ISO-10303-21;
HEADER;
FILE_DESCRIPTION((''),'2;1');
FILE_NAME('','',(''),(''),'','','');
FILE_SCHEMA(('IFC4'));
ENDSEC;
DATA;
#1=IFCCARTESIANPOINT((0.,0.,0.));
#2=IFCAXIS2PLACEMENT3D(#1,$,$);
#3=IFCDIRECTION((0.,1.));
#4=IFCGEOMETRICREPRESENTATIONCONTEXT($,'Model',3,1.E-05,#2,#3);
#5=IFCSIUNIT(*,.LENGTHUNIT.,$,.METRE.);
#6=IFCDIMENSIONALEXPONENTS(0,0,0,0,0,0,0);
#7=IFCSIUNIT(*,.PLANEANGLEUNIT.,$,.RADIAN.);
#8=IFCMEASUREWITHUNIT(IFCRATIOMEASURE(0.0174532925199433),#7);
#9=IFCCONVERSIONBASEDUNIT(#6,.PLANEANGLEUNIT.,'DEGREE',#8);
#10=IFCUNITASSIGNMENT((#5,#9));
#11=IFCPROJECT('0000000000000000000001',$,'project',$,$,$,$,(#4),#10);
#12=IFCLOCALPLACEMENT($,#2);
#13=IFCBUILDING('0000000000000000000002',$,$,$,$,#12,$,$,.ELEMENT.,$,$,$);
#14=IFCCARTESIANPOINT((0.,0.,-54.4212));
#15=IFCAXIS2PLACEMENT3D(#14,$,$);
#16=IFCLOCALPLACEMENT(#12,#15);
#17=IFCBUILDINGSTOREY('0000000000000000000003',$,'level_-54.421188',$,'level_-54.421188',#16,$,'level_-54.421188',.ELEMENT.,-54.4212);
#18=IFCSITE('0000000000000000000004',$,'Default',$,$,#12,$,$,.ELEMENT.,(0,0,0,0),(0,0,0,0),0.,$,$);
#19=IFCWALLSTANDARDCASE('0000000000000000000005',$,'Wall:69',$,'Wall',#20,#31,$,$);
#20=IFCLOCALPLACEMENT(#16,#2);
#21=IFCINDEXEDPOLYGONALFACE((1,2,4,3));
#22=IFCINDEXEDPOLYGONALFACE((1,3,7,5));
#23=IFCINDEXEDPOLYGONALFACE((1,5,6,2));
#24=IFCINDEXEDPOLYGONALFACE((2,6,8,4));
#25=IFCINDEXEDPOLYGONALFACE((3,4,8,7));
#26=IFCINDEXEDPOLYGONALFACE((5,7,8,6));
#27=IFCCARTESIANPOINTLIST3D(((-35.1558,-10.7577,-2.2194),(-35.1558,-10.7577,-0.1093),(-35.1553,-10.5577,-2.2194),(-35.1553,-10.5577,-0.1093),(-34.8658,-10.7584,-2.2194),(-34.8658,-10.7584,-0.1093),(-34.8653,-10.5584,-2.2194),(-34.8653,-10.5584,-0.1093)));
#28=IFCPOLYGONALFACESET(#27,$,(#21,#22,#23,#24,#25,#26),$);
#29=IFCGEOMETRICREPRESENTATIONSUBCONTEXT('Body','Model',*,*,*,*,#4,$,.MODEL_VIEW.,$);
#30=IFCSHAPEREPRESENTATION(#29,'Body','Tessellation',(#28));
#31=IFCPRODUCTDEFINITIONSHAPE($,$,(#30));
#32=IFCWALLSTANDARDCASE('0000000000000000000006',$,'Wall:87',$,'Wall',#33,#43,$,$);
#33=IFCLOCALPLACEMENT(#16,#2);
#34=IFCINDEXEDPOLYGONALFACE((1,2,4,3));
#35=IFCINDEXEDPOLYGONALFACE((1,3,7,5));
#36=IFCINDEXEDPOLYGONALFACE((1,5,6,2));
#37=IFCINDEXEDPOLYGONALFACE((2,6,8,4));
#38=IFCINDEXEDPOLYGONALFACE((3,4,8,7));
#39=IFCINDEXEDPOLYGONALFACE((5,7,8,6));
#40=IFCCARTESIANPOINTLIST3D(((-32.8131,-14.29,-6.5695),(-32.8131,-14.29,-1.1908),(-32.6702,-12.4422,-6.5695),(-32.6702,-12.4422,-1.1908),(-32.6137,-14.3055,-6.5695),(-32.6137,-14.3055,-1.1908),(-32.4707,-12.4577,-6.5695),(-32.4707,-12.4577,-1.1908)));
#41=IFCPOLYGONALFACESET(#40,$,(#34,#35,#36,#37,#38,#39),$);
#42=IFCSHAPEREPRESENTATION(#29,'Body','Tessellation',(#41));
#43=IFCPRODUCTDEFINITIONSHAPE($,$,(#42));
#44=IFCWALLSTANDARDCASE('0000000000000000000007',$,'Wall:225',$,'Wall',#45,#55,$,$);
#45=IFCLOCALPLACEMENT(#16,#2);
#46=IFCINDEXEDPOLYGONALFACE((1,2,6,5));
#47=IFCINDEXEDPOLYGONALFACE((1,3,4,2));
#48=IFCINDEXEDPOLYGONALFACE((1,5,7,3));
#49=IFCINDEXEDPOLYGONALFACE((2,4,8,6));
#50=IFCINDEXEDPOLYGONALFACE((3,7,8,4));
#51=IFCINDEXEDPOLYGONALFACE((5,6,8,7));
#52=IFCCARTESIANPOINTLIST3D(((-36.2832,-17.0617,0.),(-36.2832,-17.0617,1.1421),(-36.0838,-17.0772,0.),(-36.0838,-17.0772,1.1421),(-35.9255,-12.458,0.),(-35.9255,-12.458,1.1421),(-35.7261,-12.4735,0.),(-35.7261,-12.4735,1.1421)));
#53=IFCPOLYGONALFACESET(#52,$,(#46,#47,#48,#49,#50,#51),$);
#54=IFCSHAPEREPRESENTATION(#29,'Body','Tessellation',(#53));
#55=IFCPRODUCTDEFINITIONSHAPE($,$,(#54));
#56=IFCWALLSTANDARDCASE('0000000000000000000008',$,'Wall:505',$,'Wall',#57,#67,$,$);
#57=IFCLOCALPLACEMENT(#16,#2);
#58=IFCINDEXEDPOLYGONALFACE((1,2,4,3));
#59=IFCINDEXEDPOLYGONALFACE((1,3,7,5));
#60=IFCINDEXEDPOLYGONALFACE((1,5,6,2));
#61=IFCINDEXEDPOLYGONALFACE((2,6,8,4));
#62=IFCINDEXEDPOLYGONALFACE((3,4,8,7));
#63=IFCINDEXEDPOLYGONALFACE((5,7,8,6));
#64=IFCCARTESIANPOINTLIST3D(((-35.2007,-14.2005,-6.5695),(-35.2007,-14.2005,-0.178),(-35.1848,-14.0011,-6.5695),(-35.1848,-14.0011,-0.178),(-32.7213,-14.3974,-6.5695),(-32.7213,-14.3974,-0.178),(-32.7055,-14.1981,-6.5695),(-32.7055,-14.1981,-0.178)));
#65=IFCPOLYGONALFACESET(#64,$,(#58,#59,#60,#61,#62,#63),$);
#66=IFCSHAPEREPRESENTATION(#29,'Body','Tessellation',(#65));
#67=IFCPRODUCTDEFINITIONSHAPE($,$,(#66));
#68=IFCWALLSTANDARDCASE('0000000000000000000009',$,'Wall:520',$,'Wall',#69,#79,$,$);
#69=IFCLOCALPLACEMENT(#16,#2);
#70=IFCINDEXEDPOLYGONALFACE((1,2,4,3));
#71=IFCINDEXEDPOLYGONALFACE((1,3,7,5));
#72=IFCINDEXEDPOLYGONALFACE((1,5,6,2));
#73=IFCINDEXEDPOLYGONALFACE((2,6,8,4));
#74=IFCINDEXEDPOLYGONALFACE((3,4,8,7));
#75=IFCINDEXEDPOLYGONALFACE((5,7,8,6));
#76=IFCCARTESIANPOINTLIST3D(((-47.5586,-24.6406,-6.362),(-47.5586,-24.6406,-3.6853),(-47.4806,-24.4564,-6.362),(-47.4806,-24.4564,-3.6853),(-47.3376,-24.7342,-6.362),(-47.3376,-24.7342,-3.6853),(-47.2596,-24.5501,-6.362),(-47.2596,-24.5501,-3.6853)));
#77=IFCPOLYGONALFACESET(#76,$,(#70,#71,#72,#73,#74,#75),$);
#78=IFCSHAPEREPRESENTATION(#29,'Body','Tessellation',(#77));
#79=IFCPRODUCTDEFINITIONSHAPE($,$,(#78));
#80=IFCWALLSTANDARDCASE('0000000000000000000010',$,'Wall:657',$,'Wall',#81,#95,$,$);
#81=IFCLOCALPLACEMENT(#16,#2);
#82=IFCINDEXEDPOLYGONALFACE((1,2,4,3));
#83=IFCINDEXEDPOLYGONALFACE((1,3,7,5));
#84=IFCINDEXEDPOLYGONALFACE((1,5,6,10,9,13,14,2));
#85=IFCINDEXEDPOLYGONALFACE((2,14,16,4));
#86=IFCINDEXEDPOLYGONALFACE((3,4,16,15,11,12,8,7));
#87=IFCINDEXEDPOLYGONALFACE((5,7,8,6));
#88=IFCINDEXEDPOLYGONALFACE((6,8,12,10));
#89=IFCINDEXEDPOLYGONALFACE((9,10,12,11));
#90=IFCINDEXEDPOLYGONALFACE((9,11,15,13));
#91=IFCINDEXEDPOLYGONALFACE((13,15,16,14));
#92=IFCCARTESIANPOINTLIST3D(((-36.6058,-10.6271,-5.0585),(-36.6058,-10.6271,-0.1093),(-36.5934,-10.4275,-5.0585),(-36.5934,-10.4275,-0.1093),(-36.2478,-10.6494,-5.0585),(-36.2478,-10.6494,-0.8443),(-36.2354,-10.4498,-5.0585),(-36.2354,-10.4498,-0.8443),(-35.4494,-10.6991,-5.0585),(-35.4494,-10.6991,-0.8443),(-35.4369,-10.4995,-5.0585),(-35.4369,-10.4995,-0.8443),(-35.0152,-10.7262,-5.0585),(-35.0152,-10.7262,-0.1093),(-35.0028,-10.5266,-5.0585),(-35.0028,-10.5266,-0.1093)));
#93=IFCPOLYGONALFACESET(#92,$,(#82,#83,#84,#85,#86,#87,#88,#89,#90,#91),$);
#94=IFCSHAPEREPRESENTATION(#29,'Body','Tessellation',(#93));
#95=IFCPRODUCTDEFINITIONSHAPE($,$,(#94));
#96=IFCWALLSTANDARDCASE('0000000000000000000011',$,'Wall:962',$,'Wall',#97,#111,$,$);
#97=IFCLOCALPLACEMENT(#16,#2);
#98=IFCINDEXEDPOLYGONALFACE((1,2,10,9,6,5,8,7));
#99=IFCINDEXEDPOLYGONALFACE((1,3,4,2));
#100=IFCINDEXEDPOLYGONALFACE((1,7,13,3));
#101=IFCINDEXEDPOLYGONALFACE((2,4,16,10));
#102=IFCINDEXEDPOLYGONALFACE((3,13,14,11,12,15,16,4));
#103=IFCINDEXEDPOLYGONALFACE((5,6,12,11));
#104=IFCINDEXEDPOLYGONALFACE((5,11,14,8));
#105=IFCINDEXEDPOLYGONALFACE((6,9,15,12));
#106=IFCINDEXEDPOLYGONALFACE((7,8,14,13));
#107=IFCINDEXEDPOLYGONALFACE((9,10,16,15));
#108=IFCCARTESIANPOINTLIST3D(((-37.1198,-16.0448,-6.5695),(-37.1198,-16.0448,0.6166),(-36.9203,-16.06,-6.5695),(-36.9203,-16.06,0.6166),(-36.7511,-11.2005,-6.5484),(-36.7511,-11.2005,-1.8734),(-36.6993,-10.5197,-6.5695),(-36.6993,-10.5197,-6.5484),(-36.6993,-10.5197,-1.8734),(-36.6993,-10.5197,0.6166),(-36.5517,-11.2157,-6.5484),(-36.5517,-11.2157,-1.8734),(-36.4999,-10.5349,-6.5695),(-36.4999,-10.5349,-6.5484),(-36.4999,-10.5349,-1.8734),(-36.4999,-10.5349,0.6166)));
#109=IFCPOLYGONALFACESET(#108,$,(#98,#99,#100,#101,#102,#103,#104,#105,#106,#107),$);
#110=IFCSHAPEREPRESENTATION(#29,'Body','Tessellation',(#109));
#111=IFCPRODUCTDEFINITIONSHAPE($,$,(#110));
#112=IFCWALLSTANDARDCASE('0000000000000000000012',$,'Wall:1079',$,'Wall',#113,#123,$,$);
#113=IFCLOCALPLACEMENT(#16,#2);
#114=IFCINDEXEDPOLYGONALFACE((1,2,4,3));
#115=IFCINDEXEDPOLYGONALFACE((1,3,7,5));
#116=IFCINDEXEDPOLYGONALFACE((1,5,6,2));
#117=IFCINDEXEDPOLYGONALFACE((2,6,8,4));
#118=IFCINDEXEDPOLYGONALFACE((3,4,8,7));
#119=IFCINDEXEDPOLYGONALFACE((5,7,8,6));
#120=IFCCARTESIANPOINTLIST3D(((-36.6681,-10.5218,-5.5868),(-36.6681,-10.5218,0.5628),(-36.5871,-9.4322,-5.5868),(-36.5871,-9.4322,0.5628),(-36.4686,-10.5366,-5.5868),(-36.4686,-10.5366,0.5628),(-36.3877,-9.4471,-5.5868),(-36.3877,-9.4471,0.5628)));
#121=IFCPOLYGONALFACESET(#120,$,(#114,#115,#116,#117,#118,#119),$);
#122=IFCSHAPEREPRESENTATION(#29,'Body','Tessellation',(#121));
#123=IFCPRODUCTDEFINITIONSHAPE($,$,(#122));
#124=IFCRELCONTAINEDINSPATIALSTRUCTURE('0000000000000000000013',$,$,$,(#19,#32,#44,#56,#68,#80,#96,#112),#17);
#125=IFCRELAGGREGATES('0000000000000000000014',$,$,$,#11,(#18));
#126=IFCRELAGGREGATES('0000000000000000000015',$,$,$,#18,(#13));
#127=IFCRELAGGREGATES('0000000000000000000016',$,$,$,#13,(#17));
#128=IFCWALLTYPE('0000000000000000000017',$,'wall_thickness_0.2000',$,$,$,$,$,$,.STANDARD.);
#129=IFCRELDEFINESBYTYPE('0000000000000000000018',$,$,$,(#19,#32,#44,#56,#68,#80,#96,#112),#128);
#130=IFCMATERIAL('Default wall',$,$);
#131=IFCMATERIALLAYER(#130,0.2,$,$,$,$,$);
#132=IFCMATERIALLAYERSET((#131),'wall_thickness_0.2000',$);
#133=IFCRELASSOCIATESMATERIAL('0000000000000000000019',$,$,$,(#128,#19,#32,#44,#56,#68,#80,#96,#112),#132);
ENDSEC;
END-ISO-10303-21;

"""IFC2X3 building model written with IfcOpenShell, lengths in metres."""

from ifc_helpers import new_model, entity, si_unit, converted_unit, direction, frame, frame_2d, origin, place, context, subcontext, project, spatial, polyline, rectangle, outline, extrude, material, layer, layer_set, layer_usage, type_object, element, save


model = new_model("IFC2X3")

# Units and contexts
model_context = context("Model", 3, precision=1e-05, world=origin(), true_north=direction((0.0, 1.0)))
body_context = subcontext(model_context, "Body", "Model", "MODEL_VIEW")
ifc_project = project(units=[si_unit("LENGTHUNIT", "METRE"), converted_unit("PLANEANGLEUNIT", "DEGREE", entity("IfcRatioMeasure", 0.0174532925199433), si_unit("PLANEANGLEUNIT", "RADIAN"), dimensions=[0, 0, 0, 0, 0, 0, 0])], contexts=[model_context])

# Site, building, storey
placement_1 = place(None, origin())
site = spatial("IfcSite", under=ifc_project, at=placement_1, Name="Default", CompositionType="ELEMENT", RefLatitude=(0, 0, 0, 0), RefLongitude=(0, 0, 0, 0), RefElevation=0.0)
building = spatial("IfcBuilding", under=site, at=placement_1, CompositionType="ELEMENT")
storey_placement = place(placement_1, frame((0.0, 0.0, -54.4212)))
storey = spatial("IfcBuildingStorey", under=building, at=storey_placement, Name="level_-54.421188", ObjectType="level_-54.421188", LongName="level_-54.421188", CompositionType="ELEMENT", Elevation=-54.4212)

# Walls
ifc_material_1 = material(Name="Default wall")
ifc_layer = layer(ifc_material_1, 0.2)
ifc_layer_set = layer_set([ifc_layer], Name="wall_thickness_0.2000")
ifc_layer_usage = layer_usage(ifc_layer_set, "AXIS2", "POSITIVE", -0.1)
wall_type = type_object("IfcWallType", Name="wall_thickness_0.2000", PredefinedType="STANDARD", material=ifc_layer_set)
placement_2 = place(placement_1, frame((0.0, 0.0, -56.6406)))
wall_1_placement = place(placement_2, frame((-34.8656, -10.6584, 0.0), z_axis=(0.0, 0.0, 1.0), x_axis=(-0.999997, 0.002256, 0.0)))
element("IfcWallStandardCase", 1, at=wall_1_placement, inside=storey, type_object=wall_type, material=ifc_layer_usage, Name="Wall:69", ObjectType="Wall", context=body_context, shape_type="SweptSolid", body=[
    extrude(outline(polyline([(0.29, -0.1), (0.29, 0.1), (0.0, 0.1), (0.0, -0.1), (0.29, -0.1)])), origin(), (0.0, 0.0, 1.0), 2.1101),
])
placement_3 = place(placement_1, frame((0.0, 0.0, -60.9907)))
wall_2_placement = place(placement_3, frame((-32.5704, -12.4499, 0.0), z_axis=(0.0, 0.0, 1.0), x_axis=(-0.077133, -0.997021, 0.0)))
element("IfcWallStandardCase", 2, at=wall_2_placement, inside=storey, type_object=wall_type, material=ifc_layer_usage, Name="Wall:87", ObjectType="Wall", context=body_context, shape_type="SweptSolid", body=[
    extrude(outline(polyline([(1.8533, -0.1), (1.8533, 0.1), (0.0, 0.1), (0.0, -0.1), (1.8533, -0.1)])), origin(), (0.0, 0.0, 1.0), 5.3787),
])
wall_3_placement = place(storey_placement, frame((-36.1835, -17.0695, 0.0), z_axis=(0.0, 0.0, 1.0), x_axis=(0.077467, 0.996995, 0.0)))
element("IfcWallStandardCase", 3, at=wall_3_placement, inside=storey, type_object=wall_type, material=ifc_layer_usage, Name="Wall:225", ObjectType="Wall", context=body_context, shape_type="SweptSolid", body=[
    extrude(outline(polyline([(4.6176, -0.1), (4.6176, 0.1), (0.0, 0.1), (0.0, -0.1), (4.6176, -0.1)])), origin(), (0.0, 0.0, 1.0), 1.1421),
])
placement_4 = place(placement_1, frame((0.0, 0.0, -60.9907)))
wall_4_placement = place(placement_4, frame((-32.7134, -14.2977, 0.0), z_axis=(0.0, 0.0, 1.0), x_axis=(-0.996859, 0.079197, 0.0)))
element("IfcWallStandardCase", 4, at=wall_4_placement, inside=storey, type_object=wall_type, material=ifc_layer_usage, Name="Wall:505", ObjectType="Wall", context=body_context, shape_type="SweptSolid", body=[
    extrude(outline(polyline([(2.4871, -0.1), (2.4871, 0.1), (0.0, 0.1), (0.0, -0.1), (2.4871, -0.1)])), origin(), (0.0, 0.0, 1.0), 6.3915),
])
placement_5 = place(placement_1, frame((0.0, 0.0, -60.7832)))
wall_5_placement = place(placement_5, frame((-47.2986, -24.6422, 0.0), z_axis=(0.0, 0.0, 1.0), x_axis=(-0.920703, 0.390265, 0.0)))
element("IfcWallStandardCase", 5, at=wall_5_placement, inside=storey, type_object=wall_type, material=ifc_layer_usage, Name="Wall:520", ObjectType="Wall", context=body_context, shape_type="SweptSolid", body=[
    extrude(outline(polyline([(0.24, -0.1), (0.24, 0.1), (0.0, 0.1), (0.0, -0.1), (0.24, -0.1)])), origin(), (0.0, 0.0, 1.0), 2.6767),
])

# Walls, openings
placement_6 = place(placement_1, frame((0.0, 0.0, -59.4797)))
wall_6_placement = place(placement_6, frame((-35.009, -10.6264, 0.0), z_axis=(0.0, 0.0, 1.0), x_axis=(-0.998065, 0.062185, 0.0)))
wall_6 = element("IfcWallStandardCase", 6, at=wall_6_placement, inside=storey, type_object=wall_type, material=ifc_layer_usage, Name="Wall:657", ObjectType="Wall", context=body_context, shape_type="SweptSolid", body=[
    extrude(outline(polyline([(1.5937, -0.1), (1.5937, 0.1), (0.0, 0.1), (0.0, -0.1), (1.5937, -0.1)])), origin(), (0.0, 0.0, 1.0), 4.9492),
])
opening_1_placement = place(wall_6_placement, frame((0.435, -0.1, -0.0058)))
element("IfcOpeningElement", 7, at=opening_1_placement, cuts=wall_6, ObjectType="Opening", context=body_context, shape_type="SweptSolid", body=[
    extrude(rectangle(XDim=0.8, YDim=4.22, at=frame_2d((2.11, 0.4), x_axis=(0.0, 1.0))), frame((0.0, 0.0, 0.0), z_axis=(0.0, 1.0, 0.0), x_axis=(0.0, 0.0, 1.0)), (0.0, 0.0, 1.0), 0.2),
])
placement_7 = place(placement_1, frame((0.0, 0.0, -60.9907)))
wall_7_placement = place(placement_7, frame((-36.5996, -10.5273, 0.0), z_axis=(0.0, 0.0, 1.0), x_axis=(-0.075875, -0.997117, 0.0)))
wall_7 = element("IfcWallStandardCase", 8, at=wall_7_placement, inside=storey, type_object=wall_type, material=ifc_layer_usage, Name="Wall:962", ObjectType="Wall", context=body_context, shape_type="SweptSolid", body=[
    extrude(outline(polyline([(5.5411, -0.1), (5.5411, 0.1), (0.0, 0.1), (0.0, -0.1), (5.5411, -0.1)])), origin(), (0.0, 0.0, 1.0), 7.1861),
])
opening_2_placement = place(wall_7_placement, frame((-0.0522, -0.1, 0.0211)))
element("IfcOpeningElement", 9, at=opening_2_placement, cuts=wall_7, ObjectType="Opening", context=body_context, shape_type="SweptSolid", body=[
    extrude(rectangle(XDim=0.735, YDim=4.675, at=frame_2d((2.3375, 0.3675), x_axis=(0.0, 1.0))), frame((0.0, 0.0, 0.0), z_axis=(0.0, 1.0, 0.0), x_axis=(0.0, 0.0, 1.0)), (0.0, 0.0, 1.0), 0.2),
])

# Wall
placement_8 = place(placement_1, frame((0.0, 0.0, -60.008)))
wall_8_placement = place(placement_8, frame((-36.4874, -9.4396, 0.0), z_axis=(0.0, 0.0, 1.0), x_axis=(-0.074089, -0.997252, 0.0)))
element("IfcWallStandardCase", 10, at=wall_8_placement, inside=storey, type_object=wall_type, material=ifc_layer_usage, Name="Wall:1079", ObjectType="Wall", context=body_context, shape_type="SweptSolid", body=[
    extrude(outline(polyline([(1.0926, -0.1), (1.0926, 0.1), (0.0, 0.1), (0.0, -0.1), (1.0926, -0.1)])), origin(), (0.0, 0.0, 1.0), 6.1496),
])

save(model, "model.ifc")
